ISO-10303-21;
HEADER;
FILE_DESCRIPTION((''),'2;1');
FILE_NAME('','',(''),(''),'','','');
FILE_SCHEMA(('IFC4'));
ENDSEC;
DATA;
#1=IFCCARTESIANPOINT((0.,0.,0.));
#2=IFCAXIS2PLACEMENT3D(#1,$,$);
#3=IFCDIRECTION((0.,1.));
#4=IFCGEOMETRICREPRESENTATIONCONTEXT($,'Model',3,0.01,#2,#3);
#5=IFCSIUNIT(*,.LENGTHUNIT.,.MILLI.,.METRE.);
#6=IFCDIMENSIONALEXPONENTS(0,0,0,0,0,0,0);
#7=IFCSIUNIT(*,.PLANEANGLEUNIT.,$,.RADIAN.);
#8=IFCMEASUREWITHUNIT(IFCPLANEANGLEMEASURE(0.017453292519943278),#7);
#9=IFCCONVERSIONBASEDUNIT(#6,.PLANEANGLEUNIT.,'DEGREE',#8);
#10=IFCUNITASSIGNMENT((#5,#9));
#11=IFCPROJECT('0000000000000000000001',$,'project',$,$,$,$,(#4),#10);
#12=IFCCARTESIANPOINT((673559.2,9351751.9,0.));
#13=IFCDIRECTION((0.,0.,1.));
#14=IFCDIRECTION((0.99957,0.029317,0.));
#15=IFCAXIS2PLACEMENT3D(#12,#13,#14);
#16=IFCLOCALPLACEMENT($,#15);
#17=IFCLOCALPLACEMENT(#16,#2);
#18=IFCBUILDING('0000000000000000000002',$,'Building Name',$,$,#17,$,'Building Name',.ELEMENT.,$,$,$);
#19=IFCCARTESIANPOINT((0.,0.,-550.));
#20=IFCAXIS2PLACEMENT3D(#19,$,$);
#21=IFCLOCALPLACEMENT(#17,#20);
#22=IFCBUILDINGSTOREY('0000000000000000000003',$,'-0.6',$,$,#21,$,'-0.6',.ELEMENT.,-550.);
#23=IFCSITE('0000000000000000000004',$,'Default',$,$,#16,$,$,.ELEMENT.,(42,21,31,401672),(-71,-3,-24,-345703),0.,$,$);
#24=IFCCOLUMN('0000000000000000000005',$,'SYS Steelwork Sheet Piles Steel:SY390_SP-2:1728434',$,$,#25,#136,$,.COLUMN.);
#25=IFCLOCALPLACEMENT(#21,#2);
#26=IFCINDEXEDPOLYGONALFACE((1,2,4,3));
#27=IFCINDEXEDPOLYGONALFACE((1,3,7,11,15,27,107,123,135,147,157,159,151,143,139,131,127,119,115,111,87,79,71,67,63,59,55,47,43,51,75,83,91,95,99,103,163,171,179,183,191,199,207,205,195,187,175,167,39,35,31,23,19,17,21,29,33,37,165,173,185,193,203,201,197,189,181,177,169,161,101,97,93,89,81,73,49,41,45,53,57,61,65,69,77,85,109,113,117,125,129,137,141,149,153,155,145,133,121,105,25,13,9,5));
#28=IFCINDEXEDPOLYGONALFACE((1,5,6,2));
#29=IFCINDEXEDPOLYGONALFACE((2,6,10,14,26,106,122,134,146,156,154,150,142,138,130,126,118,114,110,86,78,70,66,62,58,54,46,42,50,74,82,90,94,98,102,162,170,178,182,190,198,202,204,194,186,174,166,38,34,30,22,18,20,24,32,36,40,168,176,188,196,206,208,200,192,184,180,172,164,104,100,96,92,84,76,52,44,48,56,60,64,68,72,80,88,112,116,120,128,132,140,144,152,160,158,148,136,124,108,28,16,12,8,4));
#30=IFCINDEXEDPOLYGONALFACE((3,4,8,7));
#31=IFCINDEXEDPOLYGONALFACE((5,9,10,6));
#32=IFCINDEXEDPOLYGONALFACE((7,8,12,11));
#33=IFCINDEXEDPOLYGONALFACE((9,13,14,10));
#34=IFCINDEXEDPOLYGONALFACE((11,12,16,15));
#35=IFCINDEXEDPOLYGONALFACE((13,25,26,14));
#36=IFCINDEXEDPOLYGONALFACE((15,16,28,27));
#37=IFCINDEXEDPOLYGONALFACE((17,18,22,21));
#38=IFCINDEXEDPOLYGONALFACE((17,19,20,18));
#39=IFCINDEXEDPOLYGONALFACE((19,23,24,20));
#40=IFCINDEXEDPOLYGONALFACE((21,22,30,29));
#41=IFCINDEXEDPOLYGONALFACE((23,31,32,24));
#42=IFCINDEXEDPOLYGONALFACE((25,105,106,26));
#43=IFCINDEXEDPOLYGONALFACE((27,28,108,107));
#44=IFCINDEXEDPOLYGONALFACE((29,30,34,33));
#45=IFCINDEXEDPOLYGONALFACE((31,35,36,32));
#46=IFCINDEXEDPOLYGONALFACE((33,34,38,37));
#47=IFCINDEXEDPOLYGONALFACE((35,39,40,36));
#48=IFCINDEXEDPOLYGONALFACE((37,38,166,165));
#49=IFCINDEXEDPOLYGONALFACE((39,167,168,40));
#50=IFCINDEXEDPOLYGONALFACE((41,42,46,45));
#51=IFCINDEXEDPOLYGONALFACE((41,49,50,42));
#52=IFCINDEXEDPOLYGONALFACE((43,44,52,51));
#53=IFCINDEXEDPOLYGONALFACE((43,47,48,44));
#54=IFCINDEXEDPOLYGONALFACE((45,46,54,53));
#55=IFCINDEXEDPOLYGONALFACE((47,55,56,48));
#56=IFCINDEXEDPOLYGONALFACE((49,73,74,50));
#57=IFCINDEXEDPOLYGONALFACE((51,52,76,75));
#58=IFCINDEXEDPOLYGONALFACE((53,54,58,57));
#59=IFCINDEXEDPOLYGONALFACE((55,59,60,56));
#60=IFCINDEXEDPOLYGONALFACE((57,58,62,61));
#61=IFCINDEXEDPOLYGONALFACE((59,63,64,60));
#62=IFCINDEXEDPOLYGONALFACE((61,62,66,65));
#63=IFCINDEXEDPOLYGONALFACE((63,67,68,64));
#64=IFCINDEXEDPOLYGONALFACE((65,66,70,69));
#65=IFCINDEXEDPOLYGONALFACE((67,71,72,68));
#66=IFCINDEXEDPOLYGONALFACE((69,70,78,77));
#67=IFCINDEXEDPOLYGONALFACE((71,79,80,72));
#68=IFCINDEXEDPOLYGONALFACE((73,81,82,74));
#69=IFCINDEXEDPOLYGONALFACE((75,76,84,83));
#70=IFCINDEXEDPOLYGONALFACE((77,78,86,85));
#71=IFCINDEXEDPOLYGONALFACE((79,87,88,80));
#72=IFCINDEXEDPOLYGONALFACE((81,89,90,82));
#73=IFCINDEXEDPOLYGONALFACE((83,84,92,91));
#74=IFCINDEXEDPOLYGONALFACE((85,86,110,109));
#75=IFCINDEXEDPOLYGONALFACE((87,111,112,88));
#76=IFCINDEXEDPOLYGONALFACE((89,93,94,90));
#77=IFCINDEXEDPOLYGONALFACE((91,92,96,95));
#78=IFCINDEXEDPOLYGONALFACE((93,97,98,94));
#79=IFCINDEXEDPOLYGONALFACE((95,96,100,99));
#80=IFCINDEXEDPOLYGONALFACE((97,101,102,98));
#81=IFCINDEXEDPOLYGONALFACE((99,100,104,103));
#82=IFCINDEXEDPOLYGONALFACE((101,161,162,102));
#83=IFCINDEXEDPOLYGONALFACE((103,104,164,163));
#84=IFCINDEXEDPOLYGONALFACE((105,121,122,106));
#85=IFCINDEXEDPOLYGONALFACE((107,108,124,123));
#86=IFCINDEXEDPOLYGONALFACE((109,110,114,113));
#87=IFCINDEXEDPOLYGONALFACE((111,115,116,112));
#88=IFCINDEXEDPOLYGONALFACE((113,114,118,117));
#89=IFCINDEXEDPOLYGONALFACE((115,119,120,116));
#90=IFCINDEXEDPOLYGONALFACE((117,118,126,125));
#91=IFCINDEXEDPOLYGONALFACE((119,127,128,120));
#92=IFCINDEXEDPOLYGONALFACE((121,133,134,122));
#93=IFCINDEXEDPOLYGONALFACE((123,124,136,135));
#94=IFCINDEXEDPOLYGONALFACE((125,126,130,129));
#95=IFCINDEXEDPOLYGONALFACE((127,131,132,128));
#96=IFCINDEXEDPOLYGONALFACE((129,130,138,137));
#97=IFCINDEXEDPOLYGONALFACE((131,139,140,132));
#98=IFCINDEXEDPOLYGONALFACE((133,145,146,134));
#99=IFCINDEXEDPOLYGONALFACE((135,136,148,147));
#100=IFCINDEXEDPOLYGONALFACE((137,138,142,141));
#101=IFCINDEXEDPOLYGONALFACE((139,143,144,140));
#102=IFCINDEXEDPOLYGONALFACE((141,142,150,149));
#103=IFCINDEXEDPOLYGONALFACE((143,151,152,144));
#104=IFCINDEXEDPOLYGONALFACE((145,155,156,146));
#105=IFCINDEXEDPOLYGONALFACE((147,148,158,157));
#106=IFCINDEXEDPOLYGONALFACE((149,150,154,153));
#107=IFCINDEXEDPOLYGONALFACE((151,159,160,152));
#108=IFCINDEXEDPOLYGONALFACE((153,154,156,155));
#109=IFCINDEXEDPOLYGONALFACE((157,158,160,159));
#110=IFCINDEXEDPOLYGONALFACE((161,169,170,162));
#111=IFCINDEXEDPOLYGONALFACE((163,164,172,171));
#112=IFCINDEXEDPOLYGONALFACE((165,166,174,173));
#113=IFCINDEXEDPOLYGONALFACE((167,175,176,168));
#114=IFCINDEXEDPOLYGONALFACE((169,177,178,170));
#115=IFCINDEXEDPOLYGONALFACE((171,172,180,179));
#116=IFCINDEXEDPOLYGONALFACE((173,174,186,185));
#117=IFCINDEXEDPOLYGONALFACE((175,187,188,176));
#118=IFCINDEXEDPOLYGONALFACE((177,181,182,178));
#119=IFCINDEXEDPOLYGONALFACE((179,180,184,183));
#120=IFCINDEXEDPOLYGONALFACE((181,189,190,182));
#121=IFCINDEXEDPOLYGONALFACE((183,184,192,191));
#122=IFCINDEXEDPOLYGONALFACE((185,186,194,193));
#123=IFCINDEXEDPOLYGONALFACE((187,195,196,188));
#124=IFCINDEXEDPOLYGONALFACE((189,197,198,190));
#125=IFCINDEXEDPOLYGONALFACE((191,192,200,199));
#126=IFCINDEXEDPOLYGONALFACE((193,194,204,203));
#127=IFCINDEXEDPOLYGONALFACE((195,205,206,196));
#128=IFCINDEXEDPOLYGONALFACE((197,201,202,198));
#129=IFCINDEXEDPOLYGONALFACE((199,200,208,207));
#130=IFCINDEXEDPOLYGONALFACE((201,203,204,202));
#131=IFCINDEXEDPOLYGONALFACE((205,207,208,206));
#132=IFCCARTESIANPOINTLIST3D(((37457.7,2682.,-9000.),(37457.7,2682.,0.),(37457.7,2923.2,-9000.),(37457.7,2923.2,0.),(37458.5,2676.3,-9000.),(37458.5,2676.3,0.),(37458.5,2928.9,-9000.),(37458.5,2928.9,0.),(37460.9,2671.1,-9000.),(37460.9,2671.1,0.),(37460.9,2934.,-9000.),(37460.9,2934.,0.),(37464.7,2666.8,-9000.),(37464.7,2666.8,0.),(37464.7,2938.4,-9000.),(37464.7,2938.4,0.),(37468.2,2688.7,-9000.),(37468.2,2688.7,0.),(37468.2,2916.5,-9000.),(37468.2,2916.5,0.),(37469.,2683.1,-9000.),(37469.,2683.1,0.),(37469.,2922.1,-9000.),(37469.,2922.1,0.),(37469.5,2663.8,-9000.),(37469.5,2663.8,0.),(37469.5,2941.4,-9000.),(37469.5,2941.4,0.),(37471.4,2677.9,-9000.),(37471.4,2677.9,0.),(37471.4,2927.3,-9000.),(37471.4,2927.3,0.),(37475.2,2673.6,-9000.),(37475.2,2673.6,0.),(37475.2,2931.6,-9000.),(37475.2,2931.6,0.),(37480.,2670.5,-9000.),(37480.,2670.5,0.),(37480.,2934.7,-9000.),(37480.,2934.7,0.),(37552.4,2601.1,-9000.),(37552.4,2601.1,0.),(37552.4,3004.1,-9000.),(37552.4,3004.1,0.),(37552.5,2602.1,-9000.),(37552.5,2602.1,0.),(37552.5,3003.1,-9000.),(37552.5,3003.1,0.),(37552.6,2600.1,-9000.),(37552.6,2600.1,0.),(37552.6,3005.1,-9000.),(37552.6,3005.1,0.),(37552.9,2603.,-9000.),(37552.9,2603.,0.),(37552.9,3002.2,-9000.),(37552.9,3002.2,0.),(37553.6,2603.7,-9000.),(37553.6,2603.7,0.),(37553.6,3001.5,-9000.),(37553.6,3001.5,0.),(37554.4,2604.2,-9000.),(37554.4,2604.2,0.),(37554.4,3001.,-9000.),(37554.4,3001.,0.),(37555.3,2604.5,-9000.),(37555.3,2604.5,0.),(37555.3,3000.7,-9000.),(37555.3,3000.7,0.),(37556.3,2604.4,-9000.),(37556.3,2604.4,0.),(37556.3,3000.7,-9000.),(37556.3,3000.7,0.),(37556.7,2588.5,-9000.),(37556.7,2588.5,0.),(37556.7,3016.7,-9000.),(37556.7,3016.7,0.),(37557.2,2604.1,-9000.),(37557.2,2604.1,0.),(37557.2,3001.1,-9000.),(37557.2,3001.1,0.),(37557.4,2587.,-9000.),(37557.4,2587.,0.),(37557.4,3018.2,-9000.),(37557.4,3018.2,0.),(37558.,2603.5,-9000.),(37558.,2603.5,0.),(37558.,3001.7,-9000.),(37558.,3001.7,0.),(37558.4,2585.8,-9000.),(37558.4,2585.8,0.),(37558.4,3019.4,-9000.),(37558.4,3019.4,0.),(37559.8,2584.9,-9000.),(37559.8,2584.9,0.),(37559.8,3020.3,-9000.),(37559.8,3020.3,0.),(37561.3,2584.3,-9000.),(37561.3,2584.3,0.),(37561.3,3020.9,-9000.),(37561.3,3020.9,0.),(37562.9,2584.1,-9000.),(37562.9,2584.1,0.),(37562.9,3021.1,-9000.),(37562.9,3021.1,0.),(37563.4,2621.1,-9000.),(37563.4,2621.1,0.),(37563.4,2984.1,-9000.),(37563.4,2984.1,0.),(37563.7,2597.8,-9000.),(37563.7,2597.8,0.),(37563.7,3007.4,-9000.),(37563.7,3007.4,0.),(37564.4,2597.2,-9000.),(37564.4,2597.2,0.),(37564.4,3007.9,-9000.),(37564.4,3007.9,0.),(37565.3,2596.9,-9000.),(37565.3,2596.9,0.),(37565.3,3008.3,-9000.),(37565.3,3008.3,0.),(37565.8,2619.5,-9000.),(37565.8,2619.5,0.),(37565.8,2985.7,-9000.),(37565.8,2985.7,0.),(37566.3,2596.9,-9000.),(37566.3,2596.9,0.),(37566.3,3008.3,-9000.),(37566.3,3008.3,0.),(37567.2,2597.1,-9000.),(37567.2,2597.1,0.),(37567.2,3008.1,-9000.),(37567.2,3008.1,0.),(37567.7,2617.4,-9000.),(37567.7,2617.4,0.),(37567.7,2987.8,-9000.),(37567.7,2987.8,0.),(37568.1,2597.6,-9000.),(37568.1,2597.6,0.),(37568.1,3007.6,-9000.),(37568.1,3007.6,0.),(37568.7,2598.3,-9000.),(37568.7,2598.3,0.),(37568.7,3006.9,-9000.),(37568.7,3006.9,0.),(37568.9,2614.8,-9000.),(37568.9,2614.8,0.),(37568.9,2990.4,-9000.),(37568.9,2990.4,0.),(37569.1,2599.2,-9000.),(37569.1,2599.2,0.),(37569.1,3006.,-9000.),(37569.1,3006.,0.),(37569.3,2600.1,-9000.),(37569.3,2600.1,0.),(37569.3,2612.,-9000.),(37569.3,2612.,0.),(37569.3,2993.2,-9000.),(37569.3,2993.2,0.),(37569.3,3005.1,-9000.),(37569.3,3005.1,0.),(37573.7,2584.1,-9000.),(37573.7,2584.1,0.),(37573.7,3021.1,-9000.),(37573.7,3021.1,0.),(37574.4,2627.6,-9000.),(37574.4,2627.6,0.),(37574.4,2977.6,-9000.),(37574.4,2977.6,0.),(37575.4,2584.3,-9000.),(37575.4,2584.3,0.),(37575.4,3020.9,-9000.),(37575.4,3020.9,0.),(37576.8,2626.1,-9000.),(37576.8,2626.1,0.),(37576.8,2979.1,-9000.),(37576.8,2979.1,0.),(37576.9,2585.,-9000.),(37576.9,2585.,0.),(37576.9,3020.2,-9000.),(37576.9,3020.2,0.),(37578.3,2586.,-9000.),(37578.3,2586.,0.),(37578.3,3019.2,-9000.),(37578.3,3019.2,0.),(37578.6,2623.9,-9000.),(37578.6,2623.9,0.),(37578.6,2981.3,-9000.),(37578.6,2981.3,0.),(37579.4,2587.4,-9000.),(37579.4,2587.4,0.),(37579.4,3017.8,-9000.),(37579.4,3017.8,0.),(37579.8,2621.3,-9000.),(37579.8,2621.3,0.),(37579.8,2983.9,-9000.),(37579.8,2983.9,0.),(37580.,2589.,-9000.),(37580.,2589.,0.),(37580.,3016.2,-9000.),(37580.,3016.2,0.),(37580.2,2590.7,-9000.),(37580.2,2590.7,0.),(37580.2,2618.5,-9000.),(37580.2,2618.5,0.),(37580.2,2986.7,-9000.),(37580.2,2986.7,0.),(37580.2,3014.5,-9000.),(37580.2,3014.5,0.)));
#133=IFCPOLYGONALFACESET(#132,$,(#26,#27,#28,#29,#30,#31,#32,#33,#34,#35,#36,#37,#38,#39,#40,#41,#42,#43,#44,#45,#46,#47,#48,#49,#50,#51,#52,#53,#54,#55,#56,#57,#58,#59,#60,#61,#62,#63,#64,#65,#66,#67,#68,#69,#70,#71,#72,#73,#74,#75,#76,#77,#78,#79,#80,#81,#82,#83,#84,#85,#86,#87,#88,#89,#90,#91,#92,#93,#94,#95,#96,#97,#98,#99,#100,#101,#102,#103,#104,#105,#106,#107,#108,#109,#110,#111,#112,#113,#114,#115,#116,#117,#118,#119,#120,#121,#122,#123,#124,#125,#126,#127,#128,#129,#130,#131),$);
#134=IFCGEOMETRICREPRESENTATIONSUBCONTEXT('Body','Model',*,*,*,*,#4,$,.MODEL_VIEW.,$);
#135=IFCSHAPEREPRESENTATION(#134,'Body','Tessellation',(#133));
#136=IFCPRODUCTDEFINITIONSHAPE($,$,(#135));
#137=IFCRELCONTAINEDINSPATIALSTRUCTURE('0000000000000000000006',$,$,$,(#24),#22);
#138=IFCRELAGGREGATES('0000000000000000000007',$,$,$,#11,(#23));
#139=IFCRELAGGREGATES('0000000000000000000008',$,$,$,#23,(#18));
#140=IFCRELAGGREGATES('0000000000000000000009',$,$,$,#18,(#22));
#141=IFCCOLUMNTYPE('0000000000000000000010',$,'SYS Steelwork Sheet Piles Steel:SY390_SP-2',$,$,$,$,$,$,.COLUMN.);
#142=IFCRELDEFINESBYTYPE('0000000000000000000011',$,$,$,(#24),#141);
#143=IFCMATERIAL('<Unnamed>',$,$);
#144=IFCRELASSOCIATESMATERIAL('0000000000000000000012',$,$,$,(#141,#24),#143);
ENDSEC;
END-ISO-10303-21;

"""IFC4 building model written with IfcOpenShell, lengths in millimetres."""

from ifc_helpers import new_model, entity, si_unit, converted_unit, direction, frame, origin, place, context, subcontext, project, spatial, line, arc, indexed_curve, outline, extrude, source, transform, mapped, material, type_object, type_shapes, element, save


model = new_model("IFC4")

# Units and contexts
model_context = context("Model", 3, precision=0.01, world=origin(), true_north=direction((0.0, 1.0)))
body_context = subcontext(model_context, "Body", "Model", "MODEL_VIEW")
ifc_project = project(units=[si_unit("LENGTHUNIT", "METRE", prefix="MILLI"), converted_unit("PLANEANGLEUNIT", "DEGREE", entity("IfcPlaneAngleMeasure", 0.017453292519943278), si_unit("PLANEANGLEUNIT", "RADIAN"), dimensions=[0, 0, 0, 0, 0, 0, 0])], contexts=[model_context])

# Site, building, storey
site_placement = place(None, frame((673559.2, 9351751.9, 0.0), z_axis=(0.0, 0.0, 1.0), x_axis=(0.99957, 0.029317, 0.0)))
site = spatial("IfcSite", under=ifc_project, at=site_placement, Name="Default", CompositionType="ELEMENT", RefLatitude=(42, 21, 31, 401672), RefLongitude=(-71, -3, -24, -345703), RefElevation=0.0)
building_placement = place(site_placement, origin())
building = spatial("IfcBuilding", under=site, at=building_placement, Name="Building Name", LongName="Building Name", CompositionType="ELEMENT")
storey_placement = place(building_placement, frame((0.0, 0.0, -550.0)))
storey = spatial("IfcBuildingStorey", under=building, at=storey_placement, Name="-0.6", LongName="-0.6", CompositionType="ELEMENT", Elevation=-550.0)

# Column
ifc_material_1 = material(Name="<Unnamed>")
column_type = type_object("IfcColumnType", Name="SYS Steelwork Sheet Piles Steel:SY390_SP-2", PredefinedType="COLUMN", material=ifc_material_1)
shared_shape = source(origin(), body_context, "Body", "SweptSolid", [
    extrude(outline(indexed_curve([(-120.6, 84.7), (-131.4, 81.6), (-138.8, 73.0), (-181.5, -20.9), (-185.2, -25.2), (-190.6, -26.8), (-202.5, -26.8), (-205.5, -24.8), (-204.8, -21.2), (-199.1, -15.5), (-198.6, -11.5), (-202.5, -10.1), (-214.1, -14.2), (-217.3, -16.6), (-218.5, -20.4), (-218.5, -31.2), (-216.6, -35.8), (-211.9, -37.8), (-184.1, -37.8), (-178.7, -36.2), (-175.0, -31.9), (-132.1, 62.5), (-124.7, 71.1), (-113.9, 74.2), (113.9, 74.2), (124.7, 71.1), (132.1, 62.5), (175.0, -31.9), (178.7, -36.2), (184.1, -37.8), (211.9, -37.8), (216.6, -35.8), (218.5, -31.2), (218.5, -20.4), (217.3, -16.6), (214.1, -14.2), (202.5, -10.1), (198.6, -11.5), (199.1, -15.5), (204.8, -21.2), (205.5, -24.8), (202.5, -26.8), (190.6, -26.8), (185.2, -25.2), (181.5, -20.9), (138.8, 73.0), (131.4, 81.6), (120.6, 84.7)], segments=[arc(1, 2, 3), line(3, 4), arc(4, 5, 6), line(6, 7), arc(7, 8, 9), line(9, 10), arc(10, 11, 12), line(12, 13), arc(13, 14, 15), line(15, 16), arc(16, 17, 18), line(18, 19), arc(19, 20, 21), line(21, 22), arc(22, 23, 24), line(24, 25), arc(25, 26, 27), line(27, 28), arc(28, 29, 30), line(30, 31), arc(31, 32, 33), line(33, 34), arc(34, 35, 36), line(36, 37), arc(37, 38, 39), line(39, 40), arc(40, 41, 42), line(42, 43), arc(43, 44, 45), line(45, 46), arc(46, 47, 48), line(48, 1)], self_intersect=False)), frame((0.0, 15.3, -9550.0)), (0.0, 0.0, 1.0), 9000.0),
])
type_shapes(column_type, [shared_shape])
for number, where, z_axis, x_axis, name in (
    (1, (37557.7, 2802.6, 550.0), (0.0, 0.0, 1.0), (0.0, 1.0, 0.0), "SYS Steelwork Sheet Piles Steel:SY390_SP-2:1728434"),
):
    element("IfcColumn", number, at=place(storey_placement, frame(where, z_axis=z_axis, x_axis=x_axis)), inside=storey, type_object=column_type, material=ifc_material_1, Name=name, PredefinedType="COLUMN", context=body_context, shape_type="MappedRepresentation", body=[
        mapped(shared_shape, transform((0.0, 0.0, 0.0), scale=1.0)),
    ])

save(model, "model.ifc")
